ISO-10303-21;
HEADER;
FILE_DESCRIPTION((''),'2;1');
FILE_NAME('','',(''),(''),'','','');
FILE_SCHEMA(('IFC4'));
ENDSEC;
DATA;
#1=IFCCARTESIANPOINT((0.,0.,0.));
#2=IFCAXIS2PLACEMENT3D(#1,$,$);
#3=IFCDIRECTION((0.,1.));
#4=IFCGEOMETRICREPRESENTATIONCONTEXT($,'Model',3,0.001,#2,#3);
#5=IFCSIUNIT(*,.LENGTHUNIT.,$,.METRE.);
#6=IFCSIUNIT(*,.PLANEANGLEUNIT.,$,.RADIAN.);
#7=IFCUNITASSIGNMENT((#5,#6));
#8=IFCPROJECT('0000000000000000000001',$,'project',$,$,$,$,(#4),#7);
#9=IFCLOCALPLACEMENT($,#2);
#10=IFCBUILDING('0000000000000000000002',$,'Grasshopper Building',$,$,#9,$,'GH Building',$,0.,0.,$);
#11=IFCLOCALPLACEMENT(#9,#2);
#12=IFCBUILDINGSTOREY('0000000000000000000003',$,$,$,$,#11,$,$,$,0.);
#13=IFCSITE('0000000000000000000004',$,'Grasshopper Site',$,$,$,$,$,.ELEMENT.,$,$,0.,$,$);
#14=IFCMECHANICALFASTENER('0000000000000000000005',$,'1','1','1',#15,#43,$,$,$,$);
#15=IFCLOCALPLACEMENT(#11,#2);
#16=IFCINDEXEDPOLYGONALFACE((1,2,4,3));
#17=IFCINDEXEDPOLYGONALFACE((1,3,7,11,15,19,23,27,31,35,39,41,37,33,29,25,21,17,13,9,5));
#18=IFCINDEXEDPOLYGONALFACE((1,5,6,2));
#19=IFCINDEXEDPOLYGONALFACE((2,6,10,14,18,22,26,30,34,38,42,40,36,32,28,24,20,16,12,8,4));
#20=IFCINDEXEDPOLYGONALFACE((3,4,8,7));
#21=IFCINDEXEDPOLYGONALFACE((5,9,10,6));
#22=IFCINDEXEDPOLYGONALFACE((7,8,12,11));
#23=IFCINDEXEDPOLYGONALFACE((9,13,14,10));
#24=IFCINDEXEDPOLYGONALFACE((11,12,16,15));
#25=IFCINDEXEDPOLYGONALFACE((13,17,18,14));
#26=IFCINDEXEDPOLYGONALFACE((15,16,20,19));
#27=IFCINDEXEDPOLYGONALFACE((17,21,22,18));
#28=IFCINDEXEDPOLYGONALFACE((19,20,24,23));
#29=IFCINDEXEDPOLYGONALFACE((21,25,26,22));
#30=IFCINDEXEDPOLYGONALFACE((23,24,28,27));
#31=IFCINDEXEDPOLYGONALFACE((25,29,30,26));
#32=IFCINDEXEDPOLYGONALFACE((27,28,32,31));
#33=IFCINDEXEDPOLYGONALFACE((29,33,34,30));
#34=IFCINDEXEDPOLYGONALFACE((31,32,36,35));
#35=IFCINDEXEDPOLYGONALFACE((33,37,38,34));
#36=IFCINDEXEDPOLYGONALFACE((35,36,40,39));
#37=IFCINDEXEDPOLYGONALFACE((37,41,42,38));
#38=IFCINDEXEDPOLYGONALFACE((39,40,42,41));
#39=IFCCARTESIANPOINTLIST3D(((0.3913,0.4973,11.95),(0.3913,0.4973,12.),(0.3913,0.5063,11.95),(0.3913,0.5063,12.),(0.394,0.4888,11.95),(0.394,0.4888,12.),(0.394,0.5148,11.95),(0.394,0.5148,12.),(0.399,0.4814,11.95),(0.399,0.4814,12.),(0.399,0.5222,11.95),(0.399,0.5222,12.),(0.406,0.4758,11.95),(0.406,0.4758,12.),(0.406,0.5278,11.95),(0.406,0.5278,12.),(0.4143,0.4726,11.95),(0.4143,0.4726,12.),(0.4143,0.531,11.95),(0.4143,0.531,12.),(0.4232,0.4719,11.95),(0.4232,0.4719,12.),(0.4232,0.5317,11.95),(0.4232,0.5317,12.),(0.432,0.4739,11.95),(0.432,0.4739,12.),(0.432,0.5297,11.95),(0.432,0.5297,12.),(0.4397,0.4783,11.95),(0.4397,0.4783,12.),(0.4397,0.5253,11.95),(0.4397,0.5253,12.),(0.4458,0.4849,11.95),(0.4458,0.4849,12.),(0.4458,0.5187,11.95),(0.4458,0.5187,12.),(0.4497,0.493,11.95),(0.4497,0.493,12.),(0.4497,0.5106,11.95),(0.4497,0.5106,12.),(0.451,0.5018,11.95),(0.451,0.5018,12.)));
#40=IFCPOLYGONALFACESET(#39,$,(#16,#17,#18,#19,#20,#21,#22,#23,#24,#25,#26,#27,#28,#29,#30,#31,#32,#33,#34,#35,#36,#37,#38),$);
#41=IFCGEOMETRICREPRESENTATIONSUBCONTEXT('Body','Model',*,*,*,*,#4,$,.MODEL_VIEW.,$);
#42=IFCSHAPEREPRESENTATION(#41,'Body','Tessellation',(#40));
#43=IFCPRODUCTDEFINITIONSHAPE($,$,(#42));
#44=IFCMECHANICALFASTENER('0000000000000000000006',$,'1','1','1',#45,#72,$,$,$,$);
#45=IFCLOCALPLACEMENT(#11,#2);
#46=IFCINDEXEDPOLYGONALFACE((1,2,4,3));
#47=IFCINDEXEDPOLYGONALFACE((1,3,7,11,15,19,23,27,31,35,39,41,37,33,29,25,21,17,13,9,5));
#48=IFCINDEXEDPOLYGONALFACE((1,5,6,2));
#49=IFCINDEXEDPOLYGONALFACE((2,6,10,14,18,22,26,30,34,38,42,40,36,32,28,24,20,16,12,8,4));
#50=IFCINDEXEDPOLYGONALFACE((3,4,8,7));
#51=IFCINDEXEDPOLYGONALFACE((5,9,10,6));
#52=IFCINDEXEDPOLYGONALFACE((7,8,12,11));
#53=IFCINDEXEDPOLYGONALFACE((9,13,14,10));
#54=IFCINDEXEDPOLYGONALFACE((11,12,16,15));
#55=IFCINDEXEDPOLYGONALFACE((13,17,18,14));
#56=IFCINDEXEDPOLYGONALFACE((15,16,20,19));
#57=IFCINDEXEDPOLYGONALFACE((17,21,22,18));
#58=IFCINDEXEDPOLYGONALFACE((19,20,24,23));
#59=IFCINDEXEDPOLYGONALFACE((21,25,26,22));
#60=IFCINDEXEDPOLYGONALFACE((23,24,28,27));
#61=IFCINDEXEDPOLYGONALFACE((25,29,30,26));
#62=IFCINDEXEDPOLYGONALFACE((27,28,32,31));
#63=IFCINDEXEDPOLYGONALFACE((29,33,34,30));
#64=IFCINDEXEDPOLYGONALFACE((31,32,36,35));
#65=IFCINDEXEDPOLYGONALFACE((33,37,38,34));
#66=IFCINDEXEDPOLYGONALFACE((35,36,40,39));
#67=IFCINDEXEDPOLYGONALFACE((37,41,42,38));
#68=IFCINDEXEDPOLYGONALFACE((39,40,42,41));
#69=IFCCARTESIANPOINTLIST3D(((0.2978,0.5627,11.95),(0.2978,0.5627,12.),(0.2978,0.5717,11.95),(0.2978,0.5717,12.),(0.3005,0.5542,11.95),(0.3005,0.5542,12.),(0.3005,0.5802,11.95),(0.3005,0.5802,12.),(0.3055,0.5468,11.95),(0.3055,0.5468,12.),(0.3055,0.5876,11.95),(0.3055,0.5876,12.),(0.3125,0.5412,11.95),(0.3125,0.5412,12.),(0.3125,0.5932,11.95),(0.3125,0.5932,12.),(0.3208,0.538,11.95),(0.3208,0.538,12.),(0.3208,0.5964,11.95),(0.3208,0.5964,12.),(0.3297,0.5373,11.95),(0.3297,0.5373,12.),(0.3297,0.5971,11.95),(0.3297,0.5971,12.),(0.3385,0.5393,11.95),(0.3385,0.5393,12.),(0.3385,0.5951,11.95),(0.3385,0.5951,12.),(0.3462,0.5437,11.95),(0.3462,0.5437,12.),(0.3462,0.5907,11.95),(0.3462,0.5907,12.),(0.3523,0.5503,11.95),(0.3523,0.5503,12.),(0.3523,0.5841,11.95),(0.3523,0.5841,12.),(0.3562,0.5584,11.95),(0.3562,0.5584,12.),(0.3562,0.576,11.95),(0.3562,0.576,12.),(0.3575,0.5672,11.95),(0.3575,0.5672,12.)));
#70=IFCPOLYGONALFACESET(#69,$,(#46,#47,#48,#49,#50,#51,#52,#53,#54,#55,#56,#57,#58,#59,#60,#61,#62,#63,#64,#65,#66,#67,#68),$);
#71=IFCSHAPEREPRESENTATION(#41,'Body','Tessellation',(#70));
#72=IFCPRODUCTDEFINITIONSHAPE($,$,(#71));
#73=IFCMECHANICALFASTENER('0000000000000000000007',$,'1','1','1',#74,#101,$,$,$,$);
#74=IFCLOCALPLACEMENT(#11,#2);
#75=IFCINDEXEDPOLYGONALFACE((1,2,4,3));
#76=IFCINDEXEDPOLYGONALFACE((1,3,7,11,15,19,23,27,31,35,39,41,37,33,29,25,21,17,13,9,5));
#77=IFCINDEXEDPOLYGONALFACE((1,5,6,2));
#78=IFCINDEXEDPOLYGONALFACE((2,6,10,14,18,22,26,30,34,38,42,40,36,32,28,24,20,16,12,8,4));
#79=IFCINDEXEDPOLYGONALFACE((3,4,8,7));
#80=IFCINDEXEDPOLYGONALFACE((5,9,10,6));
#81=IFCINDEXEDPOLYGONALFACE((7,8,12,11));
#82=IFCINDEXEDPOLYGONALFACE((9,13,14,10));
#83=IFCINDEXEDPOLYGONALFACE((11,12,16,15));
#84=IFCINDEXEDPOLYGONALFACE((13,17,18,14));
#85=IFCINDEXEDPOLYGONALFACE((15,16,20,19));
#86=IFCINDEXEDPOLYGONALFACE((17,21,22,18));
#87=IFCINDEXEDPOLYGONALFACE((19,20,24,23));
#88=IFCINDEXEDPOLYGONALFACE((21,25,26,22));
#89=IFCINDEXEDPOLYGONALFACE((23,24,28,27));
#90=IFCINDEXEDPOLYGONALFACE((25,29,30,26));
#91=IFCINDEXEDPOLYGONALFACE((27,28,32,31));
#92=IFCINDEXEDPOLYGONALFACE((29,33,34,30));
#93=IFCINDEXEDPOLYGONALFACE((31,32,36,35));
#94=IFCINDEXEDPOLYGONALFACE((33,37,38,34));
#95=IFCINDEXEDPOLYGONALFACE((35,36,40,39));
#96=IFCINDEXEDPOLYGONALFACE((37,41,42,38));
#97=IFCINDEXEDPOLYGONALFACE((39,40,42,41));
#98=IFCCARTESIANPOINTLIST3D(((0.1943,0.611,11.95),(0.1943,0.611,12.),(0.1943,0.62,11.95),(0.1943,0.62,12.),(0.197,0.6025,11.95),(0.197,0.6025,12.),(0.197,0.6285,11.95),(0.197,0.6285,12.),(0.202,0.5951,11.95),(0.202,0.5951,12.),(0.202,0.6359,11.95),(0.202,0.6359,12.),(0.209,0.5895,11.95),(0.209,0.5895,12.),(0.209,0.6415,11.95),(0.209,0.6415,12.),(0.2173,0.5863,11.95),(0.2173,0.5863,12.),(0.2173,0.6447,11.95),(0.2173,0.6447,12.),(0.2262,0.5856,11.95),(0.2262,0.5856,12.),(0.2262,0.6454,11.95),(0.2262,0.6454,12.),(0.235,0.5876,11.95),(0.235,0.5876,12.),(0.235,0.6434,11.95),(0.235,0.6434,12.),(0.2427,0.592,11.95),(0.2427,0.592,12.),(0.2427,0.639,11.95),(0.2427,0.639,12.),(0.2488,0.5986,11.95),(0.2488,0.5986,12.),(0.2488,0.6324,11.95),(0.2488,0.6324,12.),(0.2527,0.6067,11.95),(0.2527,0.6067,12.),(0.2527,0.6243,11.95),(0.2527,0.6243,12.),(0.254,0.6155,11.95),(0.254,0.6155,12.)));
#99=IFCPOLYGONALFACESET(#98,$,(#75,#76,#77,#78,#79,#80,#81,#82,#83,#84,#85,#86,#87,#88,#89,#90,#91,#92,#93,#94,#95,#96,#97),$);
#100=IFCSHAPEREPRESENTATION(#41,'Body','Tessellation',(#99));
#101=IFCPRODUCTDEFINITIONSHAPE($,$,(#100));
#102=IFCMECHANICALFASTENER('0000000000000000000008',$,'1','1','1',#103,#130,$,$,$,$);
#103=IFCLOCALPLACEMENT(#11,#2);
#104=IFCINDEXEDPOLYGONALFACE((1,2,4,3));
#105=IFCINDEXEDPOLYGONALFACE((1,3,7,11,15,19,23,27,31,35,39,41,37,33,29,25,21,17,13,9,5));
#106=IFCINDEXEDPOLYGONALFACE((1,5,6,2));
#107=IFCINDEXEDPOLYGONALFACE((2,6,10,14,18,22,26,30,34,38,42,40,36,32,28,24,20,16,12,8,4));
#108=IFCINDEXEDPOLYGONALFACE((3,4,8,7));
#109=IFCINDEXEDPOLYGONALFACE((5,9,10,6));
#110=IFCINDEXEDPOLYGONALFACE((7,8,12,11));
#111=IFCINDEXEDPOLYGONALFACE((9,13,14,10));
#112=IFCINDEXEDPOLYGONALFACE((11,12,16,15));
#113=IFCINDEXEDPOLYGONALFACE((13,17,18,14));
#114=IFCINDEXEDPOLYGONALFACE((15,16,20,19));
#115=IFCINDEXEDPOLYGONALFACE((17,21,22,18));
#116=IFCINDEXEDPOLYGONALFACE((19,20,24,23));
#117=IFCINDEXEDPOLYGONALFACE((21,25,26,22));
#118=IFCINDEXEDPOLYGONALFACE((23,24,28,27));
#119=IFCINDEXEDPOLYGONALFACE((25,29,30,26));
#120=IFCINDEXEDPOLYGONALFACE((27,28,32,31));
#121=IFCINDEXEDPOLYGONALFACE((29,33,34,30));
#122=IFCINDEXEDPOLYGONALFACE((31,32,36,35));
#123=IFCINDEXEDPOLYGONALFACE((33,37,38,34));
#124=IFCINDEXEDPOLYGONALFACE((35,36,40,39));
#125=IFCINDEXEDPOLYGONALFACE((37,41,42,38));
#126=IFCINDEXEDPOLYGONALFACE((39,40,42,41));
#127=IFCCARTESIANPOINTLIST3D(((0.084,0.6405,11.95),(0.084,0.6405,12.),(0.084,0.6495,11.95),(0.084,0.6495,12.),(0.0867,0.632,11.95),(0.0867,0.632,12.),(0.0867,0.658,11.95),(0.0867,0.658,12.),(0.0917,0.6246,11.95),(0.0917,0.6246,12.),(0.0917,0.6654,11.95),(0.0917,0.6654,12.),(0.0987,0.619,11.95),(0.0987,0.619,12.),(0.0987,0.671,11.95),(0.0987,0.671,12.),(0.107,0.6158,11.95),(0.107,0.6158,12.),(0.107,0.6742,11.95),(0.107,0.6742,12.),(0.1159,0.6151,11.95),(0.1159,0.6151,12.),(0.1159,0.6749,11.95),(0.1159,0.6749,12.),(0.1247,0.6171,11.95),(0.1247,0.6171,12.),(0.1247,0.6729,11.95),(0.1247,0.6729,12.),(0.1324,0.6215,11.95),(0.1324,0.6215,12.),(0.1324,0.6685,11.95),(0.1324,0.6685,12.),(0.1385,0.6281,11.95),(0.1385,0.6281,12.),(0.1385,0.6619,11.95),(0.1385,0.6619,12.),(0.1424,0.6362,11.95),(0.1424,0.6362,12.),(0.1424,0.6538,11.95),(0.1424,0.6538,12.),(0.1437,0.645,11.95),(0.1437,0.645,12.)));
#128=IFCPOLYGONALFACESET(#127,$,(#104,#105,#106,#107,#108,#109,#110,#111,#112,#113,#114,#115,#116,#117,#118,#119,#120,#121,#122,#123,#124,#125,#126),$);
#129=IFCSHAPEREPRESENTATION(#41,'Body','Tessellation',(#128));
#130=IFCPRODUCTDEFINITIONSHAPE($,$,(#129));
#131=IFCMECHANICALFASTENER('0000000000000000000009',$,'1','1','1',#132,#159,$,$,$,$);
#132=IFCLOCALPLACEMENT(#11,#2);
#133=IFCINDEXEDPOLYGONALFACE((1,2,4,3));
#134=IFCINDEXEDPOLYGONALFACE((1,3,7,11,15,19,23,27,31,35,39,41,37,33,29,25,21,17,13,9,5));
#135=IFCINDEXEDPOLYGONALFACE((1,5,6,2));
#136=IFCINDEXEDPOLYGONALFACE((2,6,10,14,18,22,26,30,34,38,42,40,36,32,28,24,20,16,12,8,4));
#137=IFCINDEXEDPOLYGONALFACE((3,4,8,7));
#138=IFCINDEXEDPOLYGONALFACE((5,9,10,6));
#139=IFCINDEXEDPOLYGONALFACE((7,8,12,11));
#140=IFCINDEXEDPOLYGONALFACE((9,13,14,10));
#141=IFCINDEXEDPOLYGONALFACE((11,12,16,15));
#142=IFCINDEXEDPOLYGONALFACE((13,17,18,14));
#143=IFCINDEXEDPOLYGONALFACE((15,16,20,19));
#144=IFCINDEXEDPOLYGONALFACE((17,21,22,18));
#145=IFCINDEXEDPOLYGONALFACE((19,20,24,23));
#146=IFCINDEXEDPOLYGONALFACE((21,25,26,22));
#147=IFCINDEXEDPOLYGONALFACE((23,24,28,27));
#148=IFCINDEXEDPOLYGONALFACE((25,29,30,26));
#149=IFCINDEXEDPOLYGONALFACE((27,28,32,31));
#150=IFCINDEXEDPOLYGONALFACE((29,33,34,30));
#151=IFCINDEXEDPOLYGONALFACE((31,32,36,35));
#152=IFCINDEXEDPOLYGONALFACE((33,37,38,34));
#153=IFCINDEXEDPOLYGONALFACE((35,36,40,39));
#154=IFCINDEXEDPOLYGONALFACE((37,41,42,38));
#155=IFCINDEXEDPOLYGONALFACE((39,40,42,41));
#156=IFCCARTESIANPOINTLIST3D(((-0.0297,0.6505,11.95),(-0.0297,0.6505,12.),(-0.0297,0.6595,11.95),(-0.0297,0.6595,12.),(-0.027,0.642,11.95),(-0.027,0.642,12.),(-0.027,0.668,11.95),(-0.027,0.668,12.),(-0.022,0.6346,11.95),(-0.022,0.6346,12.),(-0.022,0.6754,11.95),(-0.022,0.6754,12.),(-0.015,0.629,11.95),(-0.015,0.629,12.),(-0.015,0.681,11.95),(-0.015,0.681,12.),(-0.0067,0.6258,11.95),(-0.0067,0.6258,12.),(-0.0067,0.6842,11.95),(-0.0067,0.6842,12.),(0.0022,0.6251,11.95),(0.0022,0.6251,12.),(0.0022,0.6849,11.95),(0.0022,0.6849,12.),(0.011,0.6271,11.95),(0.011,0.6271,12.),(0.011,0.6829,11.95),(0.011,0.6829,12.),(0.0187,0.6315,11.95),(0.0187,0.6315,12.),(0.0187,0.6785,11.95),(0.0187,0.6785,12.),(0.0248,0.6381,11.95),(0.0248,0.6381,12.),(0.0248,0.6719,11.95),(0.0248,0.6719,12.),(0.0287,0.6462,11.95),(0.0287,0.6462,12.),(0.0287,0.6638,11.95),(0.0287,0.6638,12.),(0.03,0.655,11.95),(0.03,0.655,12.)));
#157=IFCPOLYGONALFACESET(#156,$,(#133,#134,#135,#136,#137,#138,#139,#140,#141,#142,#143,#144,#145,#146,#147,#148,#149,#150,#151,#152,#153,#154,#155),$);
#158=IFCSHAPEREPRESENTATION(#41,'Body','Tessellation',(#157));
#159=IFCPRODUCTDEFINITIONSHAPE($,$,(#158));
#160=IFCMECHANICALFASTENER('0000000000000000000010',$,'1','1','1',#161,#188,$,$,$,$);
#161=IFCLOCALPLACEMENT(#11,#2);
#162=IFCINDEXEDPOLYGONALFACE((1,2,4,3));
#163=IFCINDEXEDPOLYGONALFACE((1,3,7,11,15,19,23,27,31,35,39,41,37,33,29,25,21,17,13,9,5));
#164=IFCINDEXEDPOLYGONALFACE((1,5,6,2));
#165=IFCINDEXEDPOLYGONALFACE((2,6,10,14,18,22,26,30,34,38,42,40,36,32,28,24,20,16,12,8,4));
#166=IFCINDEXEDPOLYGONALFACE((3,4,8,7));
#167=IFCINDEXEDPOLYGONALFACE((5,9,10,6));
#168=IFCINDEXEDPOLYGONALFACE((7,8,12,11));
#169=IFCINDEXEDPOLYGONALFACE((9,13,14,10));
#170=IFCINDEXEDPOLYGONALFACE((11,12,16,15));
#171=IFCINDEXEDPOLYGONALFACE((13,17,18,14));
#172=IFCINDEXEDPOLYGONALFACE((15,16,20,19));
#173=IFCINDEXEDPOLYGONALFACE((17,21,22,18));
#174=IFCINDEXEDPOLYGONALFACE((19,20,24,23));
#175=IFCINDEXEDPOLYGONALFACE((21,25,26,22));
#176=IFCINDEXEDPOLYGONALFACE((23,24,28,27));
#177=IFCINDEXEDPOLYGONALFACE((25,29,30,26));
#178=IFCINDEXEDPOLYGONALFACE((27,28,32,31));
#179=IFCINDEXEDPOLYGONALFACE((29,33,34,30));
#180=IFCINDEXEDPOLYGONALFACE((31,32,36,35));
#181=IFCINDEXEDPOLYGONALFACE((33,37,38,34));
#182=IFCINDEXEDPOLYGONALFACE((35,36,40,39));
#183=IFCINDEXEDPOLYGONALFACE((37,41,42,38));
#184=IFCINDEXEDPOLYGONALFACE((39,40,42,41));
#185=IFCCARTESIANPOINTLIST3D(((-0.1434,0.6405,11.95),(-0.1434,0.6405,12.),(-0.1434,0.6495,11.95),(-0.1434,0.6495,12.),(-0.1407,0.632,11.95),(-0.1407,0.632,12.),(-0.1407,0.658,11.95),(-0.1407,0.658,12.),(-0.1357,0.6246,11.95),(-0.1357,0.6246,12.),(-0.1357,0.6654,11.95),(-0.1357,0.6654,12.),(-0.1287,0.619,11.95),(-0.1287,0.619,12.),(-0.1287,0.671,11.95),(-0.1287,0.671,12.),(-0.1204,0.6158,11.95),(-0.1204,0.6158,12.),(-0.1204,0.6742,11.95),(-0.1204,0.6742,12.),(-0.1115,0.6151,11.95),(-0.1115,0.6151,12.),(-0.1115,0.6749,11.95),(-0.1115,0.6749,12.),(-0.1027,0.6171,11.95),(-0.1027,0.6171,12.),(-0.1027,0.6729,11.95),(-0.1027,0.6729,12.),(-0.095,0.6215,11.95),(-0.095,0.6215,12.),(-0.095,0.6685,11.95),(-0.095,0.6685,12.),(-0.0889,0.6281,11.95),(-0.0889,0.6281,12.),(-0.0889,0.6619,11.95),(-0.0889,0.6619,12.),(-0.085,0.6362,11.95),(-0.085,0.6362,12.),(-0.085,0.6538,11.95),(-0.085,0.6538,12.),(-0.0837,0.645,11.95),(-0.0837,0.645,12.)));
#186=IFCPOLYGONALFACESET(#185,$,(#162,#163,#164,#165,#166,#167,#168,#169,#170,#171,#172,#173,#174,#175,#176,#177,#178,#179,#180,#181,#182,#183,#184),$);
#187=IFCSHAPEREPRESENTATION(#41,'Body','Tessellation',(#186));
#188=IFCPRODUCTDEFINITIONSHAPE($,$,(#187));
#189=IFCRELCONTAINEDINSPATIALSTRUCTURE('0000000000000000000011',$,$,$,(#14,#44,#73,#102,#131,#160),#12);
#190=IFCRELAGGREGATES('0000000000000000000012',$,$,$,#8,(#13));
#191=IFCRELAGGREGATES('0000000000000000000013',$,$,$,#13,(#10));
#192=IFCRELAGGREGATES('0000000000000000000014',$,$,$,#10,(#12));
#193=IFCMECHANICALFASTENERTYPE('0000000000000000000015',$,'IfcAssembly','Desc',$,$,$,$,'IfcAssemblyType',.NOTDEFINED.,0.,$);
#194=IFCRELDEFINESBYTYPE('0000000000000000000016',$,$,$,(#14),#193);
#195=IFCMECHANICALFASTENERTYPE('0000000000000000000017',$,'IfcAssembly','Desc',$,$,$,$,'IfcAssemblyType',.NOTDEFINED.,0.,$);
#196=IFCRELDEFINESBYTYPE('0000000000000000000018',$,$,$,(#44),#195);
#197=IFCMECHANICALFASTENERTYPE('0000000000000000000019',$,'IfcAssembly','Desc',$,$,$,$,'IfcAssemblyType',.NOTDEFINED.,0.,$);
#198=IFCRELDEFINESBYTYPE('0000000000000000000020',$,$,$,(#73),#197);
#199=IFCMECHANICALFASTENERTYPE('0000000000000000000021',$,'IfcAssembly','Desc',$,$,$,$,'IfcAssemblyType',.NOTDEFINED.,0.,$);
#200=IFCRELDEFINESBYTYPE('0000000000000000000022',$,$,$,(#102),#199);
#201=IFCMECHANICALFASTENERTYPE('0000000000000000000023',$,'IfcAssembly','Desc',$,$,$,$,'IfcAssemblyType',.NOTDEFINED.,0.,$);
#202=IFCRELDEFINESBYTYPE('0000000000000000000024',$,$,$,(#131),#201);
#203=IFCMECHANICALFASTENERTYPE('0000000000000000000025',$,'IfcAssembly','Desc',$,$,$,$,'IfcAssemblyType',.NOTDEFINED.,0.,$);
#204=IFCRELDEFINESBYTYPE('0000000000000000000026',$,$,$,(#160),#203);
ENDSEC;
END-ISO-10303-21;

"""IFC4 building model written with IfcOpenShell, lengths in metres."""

from ifc_helpers import new_model, si_unit, direction, frame, origin, place, context, subcontext, project, spatial, circle, extrude, source, transform, mapped, type_object, type_shapes, element, save


model = new_model("IFC4")

# Units and contexts
model_context = context("Model", 3, precision=0.001, world=origin(), true_north=direction((0.0, 1.0)))
body_context = subcontext(model_context, "Body", "Model", "MODEL_VIEW")
ifc_project = project(units=[si_unit("LENGTHUNIT", "METRE"), si_unit("PLANEANGLEUNIT", "RADIAN")], contexts=[model_context])

# Site, building, storey
site = spatial("IfcSite", under=ifc_project, Name="Grasshopper Site", CompositionType="ELEMENT", RefElevation=0.0)
building_placement = place(None, origin())
building = spatial("IfcBuilding", under=site, at=building_placement, Name="Grasshopper Building", LongName="GH Building", ElevationOfRefHeight=0.0, ElevationOfTerrain=0.0)
storey_placement = place(building_placement, origin())
storey = spatial("IfcBuildingStorey", under=building, at=storey_placement, Elevation=0.0)

# Mechanical fasteners
mechanical_fastener_type_1 = type_object("IfcMechanicalFastenerType", Name="IfcAssembly", Description="Desc", ElementType="IfcAssemblyType", NominalDiameter=0.0)
shared_shape_1 = source(origin(), body_context, "Body", "SweptSolid", [
    extrude(circle(Radius=0.03), frame((0.421, 0.5018, 12.0), z_axis=(0.0, 0.0, -1.0), x_axis=(1.0, 0.0, 0.0)), (0.0, 0.0, 1.0), 0.05),
])
type_shapes(mechanical_fastener_type_1, [shared_shape_1])
mechanical_fastener_1_placement = place(storey_placement, origin())
element("IfcMechanicalFastener", 1, at=mechanical_fastener_1_placement, inside=storey, type_object=mechanical_fastener_type_1, Name="1", Description="1", ObjectType="1", context=body_context, shape_type="MappedRepresentation", body=[
    mapped(shared_shape_1, transform((0.0, 0.0, 0.0), scale=1.0)),
])
mechanical_fastener_type_2 = type_object("IfcMechanicalFastenerType", Name="IfcAssembly", Description="Desc", ElementType="IfcAssemblyType", NominalDiameter=0.0)
shared_shape_2 = source(origin(), body_context, "Body", "SweptSolid", [
    extrude(circle(Radius=0.03), frame((0.3275, 0.5672, 12.0), z_axis=(0.0, 0.0, -1.0), x_axis=(1.0, 0.0, 0.0)), (0.0, 0.0, 1.0), 0.05),
])
type_shapes(mechanical_fastener_type_2, [shared_shape_2])
mechanical_fastener_2_placement = place(storey_placement, origin())
element("IfcMechanicalFastener", 2, at=mechanical_fastener_2_placement, inside=storey, type_object=mechanical_fastener_type_2, Name="1", Description="1", ObjectType="1", context=body_context, shape_type="MappedRepresentation", body=[
    mapped(shared_shape_2, transform((0.0, 0.0, 0.0), scale=1.0)),
])
mechanical_fastener_type_3 = type_object("IfcMechanicalFastenerType", Name="IfcAssembly", Description="Desc", ElementType="IfcAssemblyType", NominalDiameter=0.0)
shared_shape_3 = source(origin(), body_context, "Body", "SweptSolid", [
    extrude(circle(Radius=0.03), frame((0.224, 0.6155, 12.0), z_axis=(0.0, 0.0, -1.0), x_axis=(1.0, 0.0, 0.0)), (0.0, 0.0, 1.0), 0.05),
])
type_shapes(mechanical_fastener_type_3, [shared_shape_3])
mechanical_fastener_3_placement = place(storey_placement, origin())
element("IfcMechanicalFastener", 3, at=mechanical_fastener_3_placement, inside=storey, type_object=mechanical_fastener_type_3, Name="1", Description="1", ObjectType="1", context=body_context, shape_type="MappedRepresentation", body=[
    mapped(shared_shape_3, transform((0.0, 0.0, 0.0), scale=1.0)),
])
mechanical_fastener_type_4 = type_object("IfcMechanicalFastenerType", Name="IfcAssembly", Description="Desc", ElementType="IfcAssemblyType", NominalDiameter=0.0)
shared_shape_4 = source(origin(), body_context, "Body", "SweptSolid", [
    extrude(circle(Radius=0.03), frame((0.1137, 0.645, 12.0), z_axis=(0.0, 0.0, -1.0), x_axis=(1.0, 0.0, 0.0)), (0.0, 0.0, 1.0), 0.05),
])
type_shapes(mechanical_fastener_type_4, [shared_shape_4])
mechanical_fastener_4_placement = place(storey_placement, origin())
element("IfcMechanicalFastener", 4, at=mechanical_fastener_4_placement, inside=storey, type_object=mechanical_fastener_type_4, Name="1", Description="1", ObjectType="1", context=body_context, shape_type="MappedRepresentation", body=[
    mapped(shared_shape_4, transform((0.0, 0.0, 0.0), scale=1.0)),
])
mechanical_fastener_type_5 = type_object("IfcMechanicalFastenerType", Name="IfcAssembly", Description="Desc", ElementType="IfcAssemblyType", NominalDiameter=0.0)
shared_shape_5 = source(origin(), body_context, "Body", "SweptSolid", [
    extrude(circle(Radius=0.03), frame((0.0, 0.655, 12.0), z_axis=(0.0, 0.0, -1.0), x_axis=(1.0, 0.0, 0.0)), (0.0, 0.0, 1.0), 0.05),
])
type_shapes(mechanical_fastener_type_5, [shared_shape_5])
mechanical_fastener_5_placement = place(storey_placement, origin())
element("IfcMechanicalFastener", 5, at=mechanical_fastener_5_placement, inside=storey, type_object=mechanical_fastener_type_5, Name="1", Description="1", ObjectType="1", context=body_context, shape_type="MappedRepresentation", body=[
    mapped(shared_shape_5, transform((0.0, 0.0, 0.0), scale=1.0)),
])
mechanical_fastener_type_6 = type_object("IfcMechanicalFastenerType", Name="IfcAssembly", Description="Desc", ElementType="IfcAssemblyType", NominalDiameter=0.0)
shared_shape_6 = source(origin(), body_context, "Body", "SweptSolid", [
    extrude(circle(Radius=0.03), frame((-0.1137, 0.645, 12.0), z_axis=(0.0, 0.0, -1.0), x_axis=(1.0, 0.0, 0.0)), (0.0, 0.0, 1.0), 0.05),
])
type_shapes(mechanical_fastener_type_6, [shared_shape_6])
mechanical_fastener_6_placement = place(storey_placement, origin())
element("IfcMechanicalFastener", 6, at=mechanical_fastener_6_placement, inside=storey, type_object=mechanical_fastener_type_6, Name="1", Description="1", ObjectType="1", context=body_context, shape_type="MappedRepresentation", body=[
    mapped(shared_shape_6, transform((0.0, 0.0, 0.0), scale=1.0)),
])

save(model, "model.ifc")
